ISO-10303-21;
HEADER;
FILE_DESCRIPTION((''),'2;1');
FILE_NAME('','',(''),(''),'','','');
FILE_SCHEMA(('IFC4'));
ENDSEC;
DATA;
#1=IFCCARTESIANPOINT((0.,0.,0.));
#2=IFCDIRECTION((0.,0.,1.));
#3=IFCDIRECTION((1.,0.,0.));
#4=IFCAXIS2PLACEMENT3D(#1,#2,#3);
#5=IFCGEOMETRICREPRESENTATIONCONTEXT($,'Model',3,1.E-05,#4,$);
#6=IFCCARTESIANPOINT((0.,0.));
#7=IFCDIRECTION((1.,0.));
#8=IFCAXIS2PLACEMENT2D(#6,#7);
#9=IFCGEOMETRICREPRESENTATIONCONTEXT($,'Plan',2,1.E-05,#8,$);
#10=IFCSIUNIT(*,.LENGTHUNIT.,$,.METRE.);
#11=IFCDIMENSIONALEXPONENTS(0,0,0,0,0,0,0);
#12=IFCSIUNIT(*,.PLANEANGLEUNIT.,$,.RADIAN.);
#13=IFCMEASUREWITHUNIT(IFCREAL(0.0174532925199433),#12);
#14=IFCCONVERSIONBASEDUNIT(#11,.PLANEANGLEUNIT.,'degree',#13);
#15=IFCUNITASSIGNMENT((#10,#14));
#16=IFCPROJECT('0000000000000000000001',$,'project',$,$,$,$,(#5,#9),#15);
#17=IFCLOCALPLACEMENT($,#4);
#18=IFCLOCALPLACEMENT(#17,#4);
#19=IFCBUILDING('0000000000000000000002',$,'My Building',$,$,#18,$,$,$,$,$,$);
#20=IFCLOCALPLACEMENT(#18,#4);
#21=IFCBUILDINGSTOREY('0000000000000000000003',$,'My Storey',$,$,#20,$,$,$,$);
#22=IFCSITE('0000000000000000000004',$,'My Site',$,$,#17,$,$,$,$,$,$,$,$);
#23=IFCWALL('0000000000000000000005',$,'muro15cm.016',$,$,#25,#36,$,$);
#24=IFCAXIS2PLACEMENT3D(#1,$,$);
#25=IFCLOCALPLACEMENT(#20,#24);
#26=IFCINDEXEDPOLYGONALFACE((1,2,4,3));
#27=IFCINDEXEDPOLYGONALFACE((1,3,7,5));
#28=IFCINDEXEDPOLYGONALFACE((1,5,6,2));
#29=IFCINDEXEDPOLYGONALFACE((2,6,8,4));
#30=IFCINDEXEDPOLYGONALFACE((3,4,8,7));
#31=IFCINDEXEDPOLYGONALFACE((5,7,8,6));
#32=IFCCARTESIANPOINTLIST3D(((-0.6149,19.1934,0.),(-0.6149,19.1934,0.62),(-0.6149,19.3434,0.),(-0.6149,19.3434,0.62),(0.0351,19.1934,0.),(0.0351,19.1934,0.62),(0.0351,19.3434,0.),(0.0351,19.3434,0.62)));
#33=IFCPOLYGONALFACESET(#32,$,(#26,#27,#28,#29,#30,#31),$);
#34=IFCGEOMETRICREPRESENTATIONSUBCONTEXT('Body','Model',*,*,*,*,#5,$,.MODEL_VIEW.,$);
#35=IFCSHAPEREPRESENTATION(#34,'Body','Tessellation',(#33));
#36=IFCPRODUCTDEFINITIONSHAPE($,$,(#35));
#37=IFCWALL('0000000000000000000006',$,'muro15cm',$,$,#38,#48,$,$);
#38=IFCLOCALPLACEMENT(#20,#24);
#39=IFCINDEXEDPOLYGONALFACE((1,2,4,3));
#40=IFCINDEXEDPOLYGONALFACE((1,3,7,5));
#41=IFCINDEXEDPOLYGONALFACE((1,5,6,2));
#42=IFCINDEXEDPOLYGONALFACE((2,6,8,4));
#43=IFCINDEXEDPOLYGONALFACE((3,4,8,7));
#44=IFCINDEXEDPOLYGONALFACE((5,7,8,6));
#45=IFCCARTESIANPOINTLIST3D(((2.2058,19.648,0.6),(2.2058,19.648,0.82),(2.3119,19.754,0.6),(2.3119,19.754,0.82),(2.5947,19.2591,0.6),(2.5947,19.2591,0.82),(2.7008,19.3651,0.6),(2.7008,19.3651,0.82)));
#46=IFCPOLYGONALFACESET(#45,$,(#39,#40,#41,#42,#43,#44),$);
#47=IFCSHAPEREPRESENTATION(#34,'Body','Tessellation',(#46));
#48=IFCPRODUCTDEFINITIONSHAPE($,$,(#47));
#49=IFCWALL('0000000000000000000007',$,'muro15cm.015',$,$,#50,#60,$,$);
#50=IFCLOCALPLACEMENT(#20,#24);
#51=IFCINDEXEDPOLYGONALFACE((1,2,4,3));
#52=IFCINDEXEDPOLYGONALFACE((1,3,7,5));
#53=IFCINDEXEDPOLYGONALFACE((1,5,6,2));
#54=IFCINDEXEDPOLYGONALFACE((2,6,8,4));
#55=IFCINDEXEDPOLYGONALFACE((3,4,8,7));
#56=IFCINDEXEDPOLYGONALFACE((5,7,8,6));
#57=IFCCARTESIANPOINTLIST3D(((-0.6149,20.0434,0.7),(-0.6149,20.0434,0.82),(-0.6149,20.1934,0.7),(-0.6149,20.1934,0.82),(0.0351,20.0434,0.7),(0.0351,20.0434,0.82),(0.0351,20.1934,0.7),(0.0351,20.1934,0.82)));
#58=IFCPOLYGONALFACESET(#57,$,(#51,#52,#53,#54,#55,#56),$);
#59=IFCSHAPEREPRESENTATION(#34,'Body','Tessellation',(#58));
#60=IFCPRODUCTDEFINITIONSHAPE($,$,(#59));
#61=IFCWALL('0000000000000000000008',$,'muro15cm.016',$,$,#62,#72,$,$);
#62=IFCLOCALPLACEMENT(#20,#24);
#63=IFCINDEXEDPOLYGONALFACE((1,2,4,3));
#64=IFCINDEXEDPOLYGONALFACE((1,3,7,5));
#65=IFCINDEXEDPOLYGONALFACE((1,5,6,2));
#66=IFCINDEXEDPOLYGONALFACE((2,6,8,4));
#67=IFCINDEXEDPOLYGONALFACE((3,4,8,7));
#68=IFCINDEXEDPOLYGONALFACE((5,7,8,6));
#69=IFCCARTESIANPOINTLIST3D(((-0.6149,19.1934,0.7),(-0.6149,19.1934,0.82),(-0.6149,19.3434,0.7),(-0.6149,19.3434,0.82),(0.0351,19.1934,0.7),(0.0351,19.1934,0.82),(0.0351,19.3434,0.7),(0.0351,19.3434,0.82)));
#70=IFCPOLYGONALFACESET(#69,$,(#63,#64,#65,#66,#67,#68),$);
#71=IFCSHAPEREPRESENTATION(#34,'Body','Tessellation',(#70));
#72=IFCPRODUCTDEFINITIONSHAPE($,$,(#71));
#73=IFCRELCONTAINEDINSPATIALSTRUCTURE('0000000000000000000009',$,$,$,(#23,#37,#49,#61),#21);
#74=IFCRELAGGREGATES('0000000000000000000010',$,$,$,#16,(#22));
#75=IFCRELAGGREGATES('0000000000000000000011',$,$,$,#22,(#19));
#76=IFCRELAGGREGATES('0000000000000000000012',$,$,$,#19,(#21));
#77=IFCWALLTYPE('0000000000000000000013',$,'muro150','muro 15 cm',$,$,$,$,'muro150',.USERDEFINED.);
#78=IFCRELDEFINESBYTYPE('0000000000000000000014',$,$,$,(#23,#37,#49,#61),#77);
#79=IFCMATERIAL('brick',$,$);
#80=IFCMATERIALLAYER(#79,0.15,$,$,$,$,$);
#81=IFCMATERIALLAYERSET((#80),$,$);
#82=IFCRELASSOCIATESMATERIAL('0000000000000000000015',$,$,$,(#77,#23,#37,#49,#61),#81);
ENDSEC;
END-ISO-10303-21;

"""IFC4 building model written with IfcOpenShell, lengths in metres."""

from ifc_helpers import new_model, entity, si_unit, converted_unit, frame, origin_with_axes, origin_2d_with_axis, place, context, subcontext, project, spatial, indexed_curve, outline, extrude, material, layer, layer_set, layer_usage, type_object, element, save


model = new_model("IFC4")

# Units and contexts
model_context = context("Model", 3, precision=1e-05, world=origin_with_axes())
plan_context = context("Plan", 2, precision=1e-05, world=origin_2d_with_axis())
body_context = subcontext(model_context, "Body", "Model", "MODEL_VIEW")
ifc_project = project(units=[si_unit("LENGTHUNIT", "METRE"), converted_unit("PLANEANGLEUNIT", "degree", entity("IfcReal", 0.0174532925199433), si_unit("PLANEANGLEUNIT", "RADIAN"), dimensions=[0, 0, 0, 0, 0, 0, 0])], contexts=[model_context, plan_context])

# Site, building, storey
site_placement = place(None, origin_with_axes())
site = spatial("IfcSite", under=ifc_project, at=site_placement, Name="My Site")
building_placement = place(site_placement, origin_with_axes())
building = spatial("IfcBuilding", under=site, at=building_placement, Name="My Building")
storey_placement = place(building_placement, origin_with_axes())
storey = spatial("IfcBuildingStorey", under=building, at=storey_placement, Name="My Storey")

# Walls
ifc_material_1 = material(Name="brick")
ifc_layer = layer(ifc_material_1, 0.15)
ifc_layer_set = layer_set([ifc_layer])
wall_type = type_object("IfcWallType", Name="muro150", Description="muro 15 cm", ElementType="muro150", PredefinedType="USERDEFINED", material=ifc_layer_set)
ifc_layer_usage_1 = layer_usage(ifc_layer_set, "AXIS2", "POSITIVE", 0.0)
wall_1_placement = place(storey_placement, frame((0.0351, 19.3434, 0.0), z_axis=(0.0, 0.0, 1.0), x_axis=(-1.0, 0.0, 0.0)))
element("IfcWall", 1, at=wall_1_placement, inside=storey, type_object=wall_type, material=ifc_layer_usage_1, Name="muro15cm.016", context=body_context, shape_type="SweptSolid", body=[
    extrude(outline(indexed_curve([(0.0, 0.0), (0.0, 0.15), (0.65, 0.15), (0.65, 0.0), (0.0, 0.0)], self_intersect=False)), origin_with_axes(), (0.0, 0.0, 1.0), 0.62),
])
ifc_layer_usage_2 = layer_usage(ifc_layer_set, "AXIS2", "POSITIVE", 0.0)
wall_2_placement = place(storey_placement, frame((2.2058, 19.648, 0.6), z_axis=(0.0, 0.0, 1.0), x_axis=(0.707107, -0.707107, 0.0)))
element("IfcWall", 2, at=wall_2_placement, inside=storey, type_object=wall_type, material=ifc_layer_usage_2, Name="muro15cm", context=body_context, shape_type="SweptSolid", body=[
    extrude(outline(indexed_curve([(0.0, 0.0), (0.0, 0.15), (0.55, 0.15), (0.55, 0.0), (0.0, 0.0)], self_intersect=False)), origin_with_axes(), (0.0, 0.0, 1.0), 0.22),
])
ifc_layer_usage_3 = layer_usage(ifc_layer_set, "AXIS2", "POSITIVE", 0.0)
wall_3_placement = place(storey_placement, frame((0.0351, 20.1934, 0.7), z_axis=(0.0, 0.0, 1.0), x_axis=(-1.0, 0.0, 0.0)))
element("IfcWall", 3, at=wall_3_placement, inside=storey, type_object=wall_type, material=ifc_layer_usage_3, Name="muro15cm.015", context=body_context, shape_type="SweptSolid", body=[
    extrude(outline(indexed_curve([(0.0, 0.0), (0.0, 0.15), (0.65, 0.15), (0.65, 0.0), (0.0, 0.0)], self_intersect=False)), origin_with_axes(), (0.0, 0.0, 1.0), 0.12),
])
ifc_layer_usage_4 = layer_usage(ifc_layer_set, "AXIS2", "POSITIVE", 0.0)
wall_4_placement = place(storey_placement, frame((0.0351, 19.3434, 0.7), z_axis=(0.0, 0.0, 1.0), x_axis=(-1.0, 0.0, 0.0)))
element("IfcWall", 4, at=wall_4_placement, inside=storey, type_object=wall_type, material=ifc_layer_usage_4, Name="muro15cm.016", context=body_context, shape_type="SweptSolid", body=[
    extrude(outline(indexed_curve([(0.0, 0.0), (0.0, 0.15), (0.65, 0.15), (0.65, 0.0), (0.0, 0.0)], self_intersect=False)), origin_with_axes(), (0.0, 0.0, 1.0), 0.12),
])

save(model, "model.ifc")
